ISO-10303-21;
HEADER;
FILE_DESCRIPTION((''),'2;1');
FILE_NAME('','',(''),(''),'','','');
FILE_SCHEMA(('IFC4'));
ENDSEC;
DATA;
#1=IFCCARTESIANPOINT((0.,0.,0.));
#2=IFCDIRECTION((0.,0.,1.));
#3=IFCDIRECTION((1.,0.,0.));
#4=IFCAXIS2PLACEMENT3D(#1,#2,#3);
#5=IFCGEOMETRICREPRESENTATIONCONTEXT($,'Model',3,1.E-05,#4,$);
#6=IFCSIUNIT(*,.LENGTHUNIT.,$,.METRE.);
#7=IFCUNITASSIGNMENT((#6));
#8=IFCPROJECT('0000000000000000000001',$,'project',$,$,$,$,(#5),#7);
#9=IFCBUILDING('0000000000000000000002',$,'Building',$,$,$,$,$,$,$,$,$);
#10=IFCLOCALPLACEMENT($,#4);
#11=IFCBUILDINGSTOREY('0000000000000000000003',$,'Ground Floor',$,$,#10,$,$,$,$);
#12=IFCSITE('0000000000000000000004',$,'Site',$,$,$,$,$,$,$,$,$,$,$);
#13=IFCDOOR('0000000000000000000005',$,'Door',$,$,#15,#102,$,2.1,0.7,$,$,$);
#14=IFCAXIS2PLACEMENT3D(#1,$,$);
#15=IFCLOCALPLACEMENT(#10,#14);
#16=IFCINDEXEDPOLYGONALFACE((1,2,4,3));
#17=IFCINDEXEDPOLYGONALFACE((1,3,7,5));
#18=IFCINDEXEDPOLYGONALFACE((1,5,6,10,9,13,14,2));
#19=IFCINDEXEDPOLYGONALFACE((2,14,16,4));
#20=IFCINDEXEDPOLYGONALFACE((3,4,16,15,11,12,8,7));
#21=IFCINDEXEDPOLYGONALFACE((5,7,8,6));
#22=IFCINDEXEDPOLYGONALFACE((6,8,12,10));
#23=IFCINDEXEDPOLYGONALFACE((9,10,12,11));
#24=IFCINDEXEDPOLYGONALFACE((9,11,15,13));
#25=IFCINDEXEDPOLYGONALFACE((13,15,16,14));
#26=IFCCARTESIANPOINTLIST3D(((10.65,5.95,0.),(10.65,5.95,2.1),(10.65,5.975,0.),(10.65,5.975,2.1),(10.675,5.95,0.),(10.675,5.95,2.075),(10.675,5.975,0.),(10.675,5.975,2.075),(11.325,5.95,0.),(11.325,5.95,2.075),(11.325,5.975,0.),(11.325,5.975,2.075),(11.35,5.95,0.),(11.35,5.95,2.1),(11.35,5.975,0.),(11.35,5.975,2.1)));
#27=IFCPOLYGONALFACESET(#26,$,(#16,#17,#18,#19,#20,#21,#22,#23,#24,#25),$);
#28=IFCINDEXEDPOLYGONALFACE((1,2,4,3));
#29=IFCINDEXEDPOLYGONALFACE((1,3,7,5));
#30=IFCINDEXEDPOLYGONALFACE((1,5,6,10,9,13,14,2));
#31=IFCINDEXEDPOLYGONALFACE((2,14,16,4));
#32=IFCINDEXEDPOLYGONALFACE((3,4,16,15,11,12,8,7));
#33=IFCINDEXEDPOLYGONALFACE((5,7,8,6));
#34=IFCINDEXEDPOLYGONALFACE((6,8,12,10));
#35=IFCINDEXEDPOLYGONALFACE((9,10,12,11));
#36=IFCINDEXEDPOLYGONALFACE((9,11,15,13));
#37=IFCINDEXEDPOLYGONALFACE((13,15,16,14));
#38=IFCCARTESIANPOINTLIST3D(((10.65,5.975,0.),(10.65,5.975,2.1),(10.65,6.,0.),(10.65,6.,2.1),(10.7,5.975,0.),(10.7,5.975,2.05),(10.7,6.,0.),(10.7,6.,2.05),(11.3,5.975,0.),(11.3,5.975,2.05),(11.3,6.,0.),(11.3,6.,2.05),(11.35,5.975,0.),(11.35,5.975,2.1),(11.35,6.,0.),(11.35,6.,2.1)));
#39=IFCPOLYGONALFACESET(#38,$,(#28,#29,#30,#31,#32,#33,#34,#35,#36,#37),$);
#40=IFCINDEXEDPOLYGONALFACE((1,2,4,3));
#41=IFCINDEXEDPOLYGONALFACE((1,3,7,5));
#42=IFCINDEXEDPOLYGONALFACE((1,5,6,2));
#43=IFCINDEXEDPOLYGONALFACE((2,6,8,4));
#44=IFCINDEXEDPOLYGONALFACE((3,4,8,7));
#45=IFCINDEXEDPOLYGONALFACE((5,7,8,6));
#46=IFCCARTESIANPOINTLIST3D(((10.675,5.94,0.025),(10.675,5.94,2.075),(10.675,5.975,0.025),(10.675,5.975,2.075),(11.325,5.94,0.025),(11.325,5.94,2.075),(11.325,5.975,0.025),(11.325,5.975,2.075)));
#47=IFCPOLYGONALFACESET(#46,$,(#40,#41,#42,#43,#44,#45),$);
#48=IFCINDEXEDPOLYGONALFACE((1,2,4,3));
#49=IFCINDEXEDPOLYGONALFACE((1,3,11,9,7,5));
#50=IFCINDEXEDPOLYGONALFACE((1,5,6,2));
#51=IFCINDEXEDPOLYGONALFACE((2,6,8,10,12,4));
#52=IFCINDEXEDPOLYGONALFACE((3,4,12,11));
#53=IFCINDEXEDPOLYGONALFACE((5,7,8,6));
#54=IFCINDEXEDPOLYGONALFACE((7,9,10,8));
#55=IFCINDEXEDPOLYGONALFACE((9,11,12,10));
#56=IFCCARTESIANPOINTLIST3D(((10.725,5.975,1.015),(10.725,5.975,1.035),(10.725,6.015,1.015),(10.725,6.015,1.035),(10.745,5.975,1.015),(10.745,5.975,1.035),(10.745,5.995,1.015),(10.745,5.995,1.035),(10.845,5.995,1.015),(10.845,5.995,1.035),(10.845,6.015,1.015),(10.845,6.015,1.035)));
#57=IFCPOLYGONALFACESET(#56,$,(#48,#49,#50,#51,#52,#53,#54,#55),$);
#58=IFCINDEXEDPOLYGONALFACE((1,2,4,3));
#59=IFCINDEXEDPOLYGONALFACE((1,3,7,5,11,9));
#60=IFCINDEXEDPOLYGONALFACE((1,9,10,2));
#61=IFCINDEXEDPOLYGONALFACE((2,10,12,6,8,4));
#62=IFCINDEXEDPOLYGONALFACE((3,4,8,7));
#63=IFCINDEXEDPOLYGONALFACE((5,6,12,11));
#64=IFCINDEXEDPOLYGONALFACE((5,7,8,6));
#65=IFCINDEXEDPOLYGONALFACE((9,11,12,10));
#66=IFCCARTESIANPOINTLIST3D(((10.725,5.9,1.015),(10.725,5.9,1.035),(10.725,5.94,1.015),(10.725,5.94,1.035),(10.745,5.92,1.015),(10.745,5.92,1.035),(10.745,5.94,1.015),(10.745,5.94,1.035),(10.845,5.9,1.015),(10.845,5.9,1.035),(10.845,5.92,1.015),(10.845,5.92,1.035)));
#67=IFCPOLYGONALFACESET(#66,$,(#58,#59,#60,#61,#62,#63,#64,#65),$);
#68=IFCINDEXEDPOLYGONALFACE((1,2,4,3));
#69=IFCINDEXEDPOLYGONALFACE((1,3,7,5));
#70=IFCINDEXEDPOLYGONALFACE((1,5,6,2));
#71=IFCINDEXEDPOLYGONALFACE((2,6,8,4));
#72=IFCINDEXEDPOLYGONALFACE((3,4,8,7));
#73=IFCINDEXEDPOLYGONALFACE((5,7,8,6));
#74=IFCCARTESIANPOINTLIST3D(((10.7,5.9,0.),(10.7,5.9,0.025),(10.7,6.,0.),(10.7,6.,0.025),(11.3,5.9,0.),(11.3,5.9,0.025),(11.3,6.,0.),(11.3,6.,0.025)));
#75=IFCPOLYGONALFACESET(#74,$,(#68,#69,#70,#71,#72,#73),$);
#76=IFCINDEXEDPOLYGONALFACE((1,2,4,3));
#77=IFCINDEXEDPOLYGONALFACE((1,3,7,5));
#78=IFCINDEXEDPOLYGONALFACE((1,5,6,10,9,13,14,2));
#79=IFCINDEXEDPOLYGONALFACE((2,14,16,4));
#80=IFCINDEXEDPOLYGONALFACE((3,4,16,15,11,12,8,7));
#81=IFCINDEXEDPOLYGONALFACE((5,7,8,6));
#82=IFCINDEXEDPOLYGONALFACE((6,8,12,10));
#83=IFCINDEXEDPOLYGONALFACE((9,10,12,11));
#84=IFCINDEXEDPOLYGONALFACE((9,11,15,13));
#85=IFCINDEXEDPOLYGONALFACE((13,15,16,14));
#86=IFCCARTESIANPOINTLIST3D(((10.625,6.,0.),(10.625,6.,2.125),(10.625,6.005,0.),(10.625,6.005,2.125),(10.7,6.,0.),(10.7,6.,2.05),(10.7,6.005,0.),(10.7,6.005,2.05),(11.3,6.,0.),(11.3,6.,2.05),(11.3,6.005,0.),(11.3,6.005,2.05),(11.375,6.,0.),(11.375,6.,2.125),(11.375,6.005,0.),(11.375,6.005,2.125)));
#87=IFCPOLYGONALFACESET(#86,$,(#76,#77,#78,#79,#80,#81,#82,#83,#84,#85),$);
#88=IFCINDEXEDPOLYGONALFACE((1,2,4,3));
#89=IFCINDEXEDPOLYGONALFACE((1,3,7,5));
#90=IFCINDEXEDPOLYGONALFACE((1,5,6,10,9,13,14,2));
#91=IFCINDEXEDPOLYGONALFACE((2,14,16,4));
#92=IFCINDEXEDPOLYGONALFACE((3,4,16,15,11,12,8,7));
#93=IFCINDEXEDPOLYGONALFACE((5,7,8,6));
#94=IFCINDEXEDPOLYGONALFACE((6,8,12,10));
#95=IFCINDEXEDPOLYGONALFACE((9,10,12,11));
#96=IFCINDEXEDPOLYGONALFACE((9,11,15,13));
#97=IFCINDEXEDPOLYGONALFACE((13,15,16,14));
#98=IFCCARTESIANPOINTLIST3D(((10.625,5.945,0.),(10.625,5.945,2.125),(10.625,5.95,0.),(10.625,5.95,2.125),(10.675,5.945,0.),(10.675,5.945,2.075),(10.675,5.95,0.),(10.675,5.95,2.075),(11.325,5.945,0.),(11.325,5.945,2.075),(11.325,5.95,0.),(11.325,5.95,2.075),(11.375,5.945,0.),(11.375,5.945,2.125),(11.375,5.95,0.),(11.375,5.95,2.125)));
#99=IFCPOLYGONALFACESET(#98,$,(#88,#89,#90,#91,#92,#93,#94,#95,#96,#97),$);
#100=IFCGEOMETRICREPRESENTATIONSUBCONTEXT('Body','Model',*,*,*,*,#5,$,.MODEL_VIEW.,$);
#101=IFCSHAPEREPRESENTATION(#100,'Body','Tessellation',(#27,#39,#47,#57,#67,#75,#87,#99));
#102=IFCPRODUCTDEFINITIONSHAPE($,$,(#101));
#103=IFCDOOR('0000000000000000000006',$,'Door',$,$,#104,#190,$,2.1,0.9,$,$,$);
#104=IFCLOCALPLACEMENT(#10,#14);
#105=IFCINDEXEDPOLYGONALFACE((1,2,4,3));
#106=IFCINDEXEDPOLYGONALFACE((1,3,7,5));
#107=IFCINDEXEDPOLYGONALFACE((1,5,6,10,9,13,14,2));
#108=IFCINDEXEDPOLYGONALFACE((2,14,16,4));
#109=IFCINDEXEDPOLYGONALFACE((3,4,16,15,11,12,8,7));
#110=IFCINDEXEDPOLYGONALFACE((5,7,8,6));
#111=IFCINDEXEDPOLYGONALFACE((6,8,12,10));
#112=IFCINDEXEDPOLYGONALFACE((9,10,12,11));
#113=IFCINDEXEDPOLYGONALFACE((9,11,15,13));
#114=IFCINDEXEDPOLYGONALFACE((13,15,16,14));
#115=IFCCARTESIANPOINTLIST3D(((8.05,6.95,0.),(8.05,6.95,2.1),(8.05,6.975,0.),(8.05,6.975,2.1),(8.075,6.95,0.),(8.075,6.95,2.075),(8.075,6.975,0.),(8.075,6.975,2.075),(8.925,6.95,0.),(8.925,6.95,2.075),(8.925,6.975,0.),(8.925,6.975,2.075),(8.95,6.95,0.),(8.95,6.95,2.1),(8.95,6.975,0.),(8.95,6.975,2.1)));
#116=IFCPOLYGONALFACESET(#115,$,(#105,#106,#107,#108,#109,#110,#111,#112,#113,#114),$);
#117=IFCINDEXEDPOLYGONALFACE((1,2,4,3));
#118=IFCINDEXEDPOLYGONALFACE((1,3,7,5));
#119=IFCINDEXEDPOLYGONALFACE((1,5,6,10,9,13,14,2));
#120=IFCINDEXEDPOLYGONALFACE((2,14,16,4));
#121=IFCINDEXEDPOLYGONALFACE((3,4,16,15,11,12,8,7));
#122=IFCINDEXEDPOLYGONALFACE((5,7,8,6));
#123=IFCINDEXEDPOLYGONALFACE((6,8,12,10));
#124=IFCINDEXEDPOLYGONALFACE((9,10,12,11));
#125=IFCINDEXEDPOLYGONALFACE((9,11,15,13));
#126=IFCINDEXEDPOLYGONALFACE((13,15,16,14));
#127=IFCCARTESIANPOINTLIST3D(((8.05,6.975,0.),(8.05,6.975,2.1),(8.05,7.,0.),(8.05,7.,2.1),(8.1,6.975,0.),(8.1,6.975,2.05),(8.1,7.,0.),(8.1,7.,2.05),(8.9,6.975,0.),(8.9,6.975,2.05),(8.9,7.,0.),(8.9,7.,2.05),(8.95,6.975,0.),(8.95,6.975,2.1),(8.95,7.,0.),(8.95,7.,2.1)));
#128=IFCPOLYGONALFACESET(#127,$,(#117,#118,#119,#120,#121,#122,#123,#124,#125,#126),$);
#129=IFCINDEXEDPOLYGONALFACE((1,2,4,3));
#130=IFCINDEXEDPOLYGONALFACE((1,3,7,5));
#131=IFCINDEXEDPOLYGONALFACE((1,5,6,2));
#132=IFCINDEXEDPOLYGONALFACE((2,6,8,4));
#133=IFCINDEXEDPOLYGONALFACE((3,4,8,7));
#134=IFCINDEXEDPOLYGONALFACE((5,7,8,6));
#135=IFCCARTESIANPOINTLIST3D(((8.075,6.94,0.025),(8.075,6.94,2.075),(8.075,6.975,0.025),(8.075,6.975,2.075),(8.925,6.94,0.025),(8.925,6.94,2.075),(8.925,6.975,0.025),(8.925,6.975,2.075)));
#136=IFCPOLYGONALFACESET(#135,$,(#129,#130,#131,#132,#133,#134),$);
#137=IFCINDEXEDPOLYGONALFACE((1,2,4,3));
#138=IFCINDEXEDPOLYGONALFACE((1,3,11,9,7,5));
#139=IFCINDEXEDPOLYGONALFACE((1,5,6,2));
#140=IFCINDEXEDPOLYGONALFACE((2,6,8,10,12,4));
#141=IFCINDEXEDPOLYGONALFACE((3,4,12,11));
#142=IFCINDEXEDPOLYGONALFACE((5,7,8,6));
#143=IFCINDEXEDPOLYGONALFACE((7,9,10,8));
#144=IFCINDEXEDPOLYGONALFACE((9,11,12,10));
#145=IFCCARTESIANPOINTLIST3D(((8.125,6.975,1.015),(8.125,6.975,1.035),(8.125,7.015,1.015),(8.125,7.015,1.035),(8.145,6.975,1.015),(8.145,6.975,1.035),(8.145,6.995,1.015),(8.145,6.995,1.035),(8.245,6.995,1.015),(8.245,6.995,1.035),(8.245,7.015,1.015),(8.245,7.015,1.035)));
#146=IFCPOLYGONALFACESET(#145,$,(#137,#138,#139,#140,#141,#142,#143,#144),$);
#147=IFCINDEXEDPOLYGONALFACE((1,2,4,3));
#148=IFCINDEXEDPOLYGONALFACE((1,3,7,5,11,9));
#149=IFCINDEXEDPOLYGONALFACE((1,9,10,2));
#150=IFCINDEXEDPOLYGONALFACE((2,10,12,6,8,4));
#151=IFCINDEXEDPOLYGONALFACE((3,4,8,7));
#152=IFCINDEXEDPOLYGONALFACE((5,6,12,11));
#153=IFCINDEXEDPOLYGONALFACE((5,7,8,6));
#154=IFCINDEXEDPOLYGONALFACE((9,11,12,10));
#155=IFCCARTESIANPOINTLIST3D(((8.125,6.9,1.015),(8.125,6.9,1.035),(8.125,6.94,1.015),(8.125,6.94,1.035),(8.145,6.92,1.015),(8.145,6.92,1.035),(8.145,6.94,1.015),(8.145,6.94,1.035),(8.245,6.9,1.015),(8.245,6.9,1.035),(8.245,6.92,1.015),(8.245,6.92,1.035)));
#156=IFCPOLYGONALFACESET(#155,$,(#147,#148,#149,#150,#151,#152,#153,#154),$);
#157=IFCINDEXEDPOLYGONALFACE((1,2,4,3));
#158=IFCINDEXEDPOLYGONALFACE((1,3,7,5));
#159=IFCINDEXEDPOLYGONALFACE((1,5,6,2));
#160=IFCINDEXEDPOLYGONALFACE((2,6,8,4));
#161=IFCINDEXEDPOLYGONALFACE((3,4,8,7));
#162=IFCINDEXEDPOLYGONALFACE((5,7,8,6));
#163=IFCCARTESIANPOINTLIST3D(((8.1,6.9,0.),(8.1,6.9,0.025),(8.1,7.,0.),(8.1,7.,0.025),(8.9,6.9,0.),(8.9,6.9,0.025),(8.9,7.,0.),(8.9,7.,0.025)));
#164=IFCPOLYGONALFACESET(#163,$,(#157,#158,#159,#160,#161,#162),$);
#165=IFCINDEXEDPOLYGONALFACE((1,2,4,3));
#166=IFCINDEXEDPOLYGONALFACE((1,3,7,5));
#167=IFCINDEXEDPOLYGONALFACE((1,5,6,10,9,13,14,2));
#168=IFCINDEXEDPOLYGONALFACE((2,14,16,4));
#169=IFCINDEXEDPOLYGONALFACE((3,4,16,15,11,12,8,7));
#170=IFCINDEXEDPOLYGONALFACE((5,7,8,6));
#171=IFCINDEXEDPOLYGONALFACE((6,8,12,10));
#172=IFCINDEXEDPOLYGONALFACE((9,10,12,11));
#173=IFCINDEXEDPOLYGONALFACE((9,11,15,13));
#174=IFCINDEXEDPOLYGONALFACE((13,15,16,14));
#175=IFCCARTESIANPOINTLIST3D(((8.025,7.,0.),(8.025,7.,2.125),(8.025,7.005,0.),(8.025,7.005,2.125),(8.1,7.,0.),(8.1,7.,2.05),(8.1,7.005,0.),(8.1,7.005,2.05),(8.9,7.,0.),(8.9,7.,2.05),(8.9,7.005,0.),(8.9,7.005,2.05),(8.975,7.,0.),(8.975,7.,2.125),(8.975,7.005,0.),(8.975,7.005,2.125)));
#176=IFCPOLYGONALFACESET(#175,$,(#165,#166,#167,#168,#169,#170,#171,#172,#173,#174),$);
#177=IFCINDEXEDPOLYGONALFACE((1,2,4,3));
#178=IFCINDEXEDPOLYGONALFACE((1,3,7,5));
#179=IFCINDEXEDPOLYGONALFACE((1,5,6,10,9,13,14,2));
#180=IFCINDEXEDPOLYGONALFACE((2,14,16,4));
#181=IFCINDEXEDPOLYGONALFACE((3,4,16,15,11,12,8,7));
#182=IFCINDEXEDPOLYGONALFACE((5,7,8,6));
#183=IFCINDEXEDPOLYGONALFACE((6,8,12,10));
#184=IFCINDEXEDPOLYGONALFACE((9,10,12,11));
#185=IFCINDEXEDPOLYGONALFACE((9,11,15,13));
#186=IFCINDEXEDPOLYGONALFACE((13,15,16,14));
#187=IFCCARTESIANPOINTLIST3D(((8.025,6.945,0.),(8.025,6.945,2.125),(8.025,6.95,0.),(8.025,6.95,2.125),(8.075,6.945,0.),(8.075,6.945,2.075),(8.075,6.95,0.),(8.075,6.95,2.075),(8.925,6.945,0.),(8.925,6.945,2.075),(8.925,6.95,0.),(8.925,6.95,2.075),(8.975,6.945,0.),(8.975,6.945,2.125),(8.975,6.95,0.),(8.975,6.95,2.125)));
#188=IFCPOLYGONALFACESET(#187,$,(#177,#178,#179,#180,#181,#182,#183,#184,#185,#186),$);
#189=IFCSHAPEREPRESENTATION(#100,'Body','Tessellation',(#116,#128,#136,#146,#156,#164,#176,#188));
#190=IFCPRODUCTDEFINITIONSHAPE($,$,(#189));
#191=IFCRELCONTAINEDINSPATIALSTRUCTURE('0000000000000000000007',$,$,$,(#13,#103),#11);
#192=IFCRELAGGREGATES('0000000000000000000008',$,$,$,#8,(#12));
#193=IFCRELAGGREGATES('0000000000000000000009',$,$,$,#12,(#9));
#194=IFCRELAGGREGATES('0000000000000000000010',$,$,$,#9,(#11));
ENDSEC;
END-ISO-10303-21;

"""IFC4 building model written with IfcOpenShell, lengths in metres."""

from ifc_helpers import new_model, si_unit, frame, origin_with_axes, place, context, subcontext, project, spatial, line, indexed_curve, outline, extrude, element, save


model = new_model("IFC4")

# Units and contexts
model_context = context("Model", 3, precision=1e-05, world=origin_with_axes())
body_context = subcontext(model_context, "Body", "Model", "MODEL_VIEW")
ifc_project = project(units=[si_unit("LENGTHUNIT", "METRE")], contexts=[model_context])

# Site, building, storey
site = spatial("IfcSite", under=ifc_project, Name="Site")
building = spatial("IfcBuilding", under=site, Name="Building")
storey_placement = place(None, origin_with_axes())
storey = spatial("IfcBuildingStorey", under=building, at=storey_placement, Name="Ground Floor")

# Doors
door_1_placement = place(storey_placement, frame((11.35, 6.0, 0.0), z_axis=(0.0, 0.0, 1.0), x_axis=(-1.0, 0.0, 0.0)))
element("IfcDoor", 1, at=door_1_placement, inside=storey, Name="Door", OverallHeight=2.1, OverallWidth=0.7, context=body_context, shape_type="SweptSolid", body=[
    extrude(outline(indexed_curve([(0.0, 0.0), (0.0, 2.1), (0.7, 2.1), (0.7, 0.0), (0.675, 0.0), (0.675, 2.075), (0.025, 2.075), (0.025, 0.0)], segments=[line(1, 2, 3, 4, 5, 6, 7, 8, 1)])), frame((0.0, 0.025, 0.0), z_axis=(0.0, -1.0, 0.0), x_axis=(1.0, 0.0, 0.0)), (0.0, 0.0, -1.0), 0.025),
    extrude(outline(indexed_curve([(0.0, 0.0), (0.0, 2.1), (0.7, 2.1), (0.7, 0.0), (0.65, 0.0), (0.65, 2.05), (0.05, 2.05), (0.05, 0.0)], segments=[line(1, 2, 3, 4, 5, 6, 7, 8, 1)])), frame((0.0, 0.0, 0.0), z_axis=(0.0, -1.0, 0.0), x_axis=(1.0, 0.0, 0.0)), (0.0, 0.0, -1.0), 0.025),
    extrude(outline(indexed_curve([(0.0, 0.0), (0.65, 0.0), (0.65, 0.035), (0.0, 0.035)], segments=[line(1, 2, 3, 4, 1)])), frame((0.025, 0.025, 0.025), z_axis=(0.0, 0.0, 1.0), x_axis=(1.0, 0.0, 0.0)), (0.0, 0.0, 1.0), 2.05),
    extrude(outline(indexed_curve([(0.0, 0.0), (0.0, -0.04), (-0.12, -0.04), (-0.12, -0.02), (-0.02, -0.02), (-0.02, 0.0)], segments=[line(1, 2, 3, 4, 5, 6, 1)])), frame((0.625, 0.025, 1.015), z_axis=(0.0, 0.0, 1.0), x_axis=(1.0, 0.0, 0.0)), (0.0, 0.0, 1.0), 0.02),
    extrude(outline(indexed_curve([(0.0, 0.0), (0.0, 0.04), (-0.12, 0.04), (-0.12, 0.02), (-0.02, 0.02), (-0.02, 0.0)], segments=[line(1, 2, 3, 4, 5, 6, 1)])), frame((0.625, 0.06, 1.015), z_axis=(0.0, 0.0, 1.0), x_axis=(1.0, 0.0, 0.0)), (0.0, 0.0, 1.0), 0.02),
    extrude(outline(indexed_curve([(0.0, 0.0), (0.6, 0.0), (0.6, 0.1), (0.0, 0.1)], segments=[line(1, 2, 3, 4, 1)])), frame((0.05, 0.0, 0.0), z_axis=(0.0, 0.0, 1.0), x_axis=(1.0, 0.0, 0.0)), (0.0, 0.0, 1.0), 0.025),
    extrude(outline(indexed_curve([(0.0, 0.0), (0.0, 2.125), (0.75, 2.125), (0.75, 0.0), (0.675, 0.0), (0.675, 2.05), (0.075, 2.05), (0.075, 0.0)], segments=[line(1, 2, 3, 4, 5, 6, 7, 8, 1)])), frame((-0.025, -0.005, 0.0), z_axis=(0.0, -1.0, 0.0), x_axis=(1.0, 0.0, 0.0)), (0.0, 0.0, -1.0), 0.005),
    extrude(outline(indexed_curve([(0.0, 0.0), (0.0, 2.125), (0.75, 2.125), (0.75, 0.0), (0.7, 0.0), (0.7, 2.075), (0.05, 2.075), (0.05, 0.0)], segments=[line(1, 2, 3, 4, 5, 6, 7, 8, 1)])), frame((-0.025, 0.05, 0.0), z_axis=(0.0, -1.0, 0.0), x_axis=(1.0, 0.0, 0.0)), (0.0, 0.0, -1.0), 0.005),
])
door_2_placement = place(storey_placement, frame((8.95, 7.0, 0.0), z_axis=(0.0, 0.0, 1.0), x_axis=(-1.0, 0.0, 0.0)))
element("IfcDoor", 2, at=door_2_placement, inside=storey, Name="Door", OverallHeight=2.1, OverallWidth=0.9, context=body_context, shape_type="SweptSolid", body=[
    extrude(outline(indexed_curve([(0.0, 0.0), (0.0, 2.1), (0.9, 2.1), (0.9, 0.0), (0.875, 0.0), (0.875, 2.075), (0.025, 2.075), (0.025, 0.0)], segments=[line(1, 2, 3, 4, 5, 6, 7, 8, 1)])), frame((0.0, 0.025, 0.0), z_axis=(0.0, -1.0, 0.0), x_axis=(1.0, 0.0, 0.0)), (0.0, 0.0, -1.0), 0.025),
    extrude(outline(indexed_curve([(0.0, 0.0), (0.0, 2.1), (0.9, 2.1), (0.9, 0.0), (0.85, 0.0), (0.85, 2.05), (0.05, 2.05), (0.05, 0.0)], segments=[line(1, 2, 3, 4, 5, 6, 7, 8, 1)])), frame((0.0, 0.0, 0.0), z_axis=(0.0, -1.0, 0.0), x_axis=(1.0, 0.0, 0.0)), (0.0, 0.0, -1.0), 0.025),
    extrude(outline(indexed_curve([(0.0, 0.0), (0.85, 0.0), (0.85, 0.035), (0.0, 0.035)], segments=[line(1, 2, 3, 4, 1)])), frame((0.025, 0.025, 0.025), z_axis=(0.0, 0.0, 1.0), x_axis=(1.0, 0.0, 0.0)), (0.0, 0.0, 1.0), 2.05),
    extrude(outline(indexed_curve([(0.0, 0.0), (0.0, -0.04), (-0.12, -0.04), (-0.12, -0.02), (-0.02, -0.02), (-0.02, 0.0)], segments=[line(1, 2, 3, 4, 5, 6, 1)])), frame((0.825, 0.025, 1.015), z_axis=(0.0, 0.0, 1.0), x_axis=(1.0, 0.0, 0.0)), (0.0, 0.0, 1.0), 0.02),
    extrude(outline(indexed_curve([(0.0, 0.0), (0.0, 0.04), (-0.12, 0.04), (-0.12, 0.02), (-0.02, 0.02), (-0.02, 0.0)], segments=[line(1, 2, 3, 4, 5, 6, 1)])), frame((0.825, 0.06, 1.015), z_axis=(0.0, 0.0, 1.0), x_axis=(1.0, 0.0, 0.0)), (0.0, 0.0, 1.0), 0.02),
    extrude(outline(indexed_curve([(0.0, 0.0), (0.8, 0.0), (0.8, 0.1), (0.0, 0.1)], segments=[line(1, 2, 3, 4, 1)])), frame((0.05, 0.0, 0.0), z_axis=(0.0, 0.0, 1.0), x_axis=(1.0, 0.0, 0.0)), (0.0, 0.0, 1.0), 0.025),
    extrude(outline(indexed_curve([(0.0, 0.0), (0.0, 2.125), (0.95, 2.125), (0.95, 0.0), (0.875, 0.0), (0.875, 2.05), (0.075, 2.05), (0.075, 0.0)], segments=[line(1, 2, 3, 4, 5, 6, 7, 8, 1)])), frame((-0.025, -0.005, 0.0), z_axis=(0.0, -1.0, 0.0), x_axis=(1.0, 0.0, 0.0)), (0.0, 0.0, -1.0), 0.005),
    extrude(outline(indexed_curve([(0.0, 0.0), (0.0, 2.125), (0.95, 2.125), (0.95, 0.0), (0.9, 0.0), (0.9, 2.075), (0.05, 2.075), (0.05, 0.0)], segments=[line(1, 2, 3, 4, 5, 6, 7, 8, 1)])), frame((-0.025, 0.05, 0.0), z_axis=(0.0, -1.0, 0.0), x_axis=(1.0, 0.0, 0.0)), (0.0, 0.0, -1.0), 0.005),
])

save(model, "model.ifc")
